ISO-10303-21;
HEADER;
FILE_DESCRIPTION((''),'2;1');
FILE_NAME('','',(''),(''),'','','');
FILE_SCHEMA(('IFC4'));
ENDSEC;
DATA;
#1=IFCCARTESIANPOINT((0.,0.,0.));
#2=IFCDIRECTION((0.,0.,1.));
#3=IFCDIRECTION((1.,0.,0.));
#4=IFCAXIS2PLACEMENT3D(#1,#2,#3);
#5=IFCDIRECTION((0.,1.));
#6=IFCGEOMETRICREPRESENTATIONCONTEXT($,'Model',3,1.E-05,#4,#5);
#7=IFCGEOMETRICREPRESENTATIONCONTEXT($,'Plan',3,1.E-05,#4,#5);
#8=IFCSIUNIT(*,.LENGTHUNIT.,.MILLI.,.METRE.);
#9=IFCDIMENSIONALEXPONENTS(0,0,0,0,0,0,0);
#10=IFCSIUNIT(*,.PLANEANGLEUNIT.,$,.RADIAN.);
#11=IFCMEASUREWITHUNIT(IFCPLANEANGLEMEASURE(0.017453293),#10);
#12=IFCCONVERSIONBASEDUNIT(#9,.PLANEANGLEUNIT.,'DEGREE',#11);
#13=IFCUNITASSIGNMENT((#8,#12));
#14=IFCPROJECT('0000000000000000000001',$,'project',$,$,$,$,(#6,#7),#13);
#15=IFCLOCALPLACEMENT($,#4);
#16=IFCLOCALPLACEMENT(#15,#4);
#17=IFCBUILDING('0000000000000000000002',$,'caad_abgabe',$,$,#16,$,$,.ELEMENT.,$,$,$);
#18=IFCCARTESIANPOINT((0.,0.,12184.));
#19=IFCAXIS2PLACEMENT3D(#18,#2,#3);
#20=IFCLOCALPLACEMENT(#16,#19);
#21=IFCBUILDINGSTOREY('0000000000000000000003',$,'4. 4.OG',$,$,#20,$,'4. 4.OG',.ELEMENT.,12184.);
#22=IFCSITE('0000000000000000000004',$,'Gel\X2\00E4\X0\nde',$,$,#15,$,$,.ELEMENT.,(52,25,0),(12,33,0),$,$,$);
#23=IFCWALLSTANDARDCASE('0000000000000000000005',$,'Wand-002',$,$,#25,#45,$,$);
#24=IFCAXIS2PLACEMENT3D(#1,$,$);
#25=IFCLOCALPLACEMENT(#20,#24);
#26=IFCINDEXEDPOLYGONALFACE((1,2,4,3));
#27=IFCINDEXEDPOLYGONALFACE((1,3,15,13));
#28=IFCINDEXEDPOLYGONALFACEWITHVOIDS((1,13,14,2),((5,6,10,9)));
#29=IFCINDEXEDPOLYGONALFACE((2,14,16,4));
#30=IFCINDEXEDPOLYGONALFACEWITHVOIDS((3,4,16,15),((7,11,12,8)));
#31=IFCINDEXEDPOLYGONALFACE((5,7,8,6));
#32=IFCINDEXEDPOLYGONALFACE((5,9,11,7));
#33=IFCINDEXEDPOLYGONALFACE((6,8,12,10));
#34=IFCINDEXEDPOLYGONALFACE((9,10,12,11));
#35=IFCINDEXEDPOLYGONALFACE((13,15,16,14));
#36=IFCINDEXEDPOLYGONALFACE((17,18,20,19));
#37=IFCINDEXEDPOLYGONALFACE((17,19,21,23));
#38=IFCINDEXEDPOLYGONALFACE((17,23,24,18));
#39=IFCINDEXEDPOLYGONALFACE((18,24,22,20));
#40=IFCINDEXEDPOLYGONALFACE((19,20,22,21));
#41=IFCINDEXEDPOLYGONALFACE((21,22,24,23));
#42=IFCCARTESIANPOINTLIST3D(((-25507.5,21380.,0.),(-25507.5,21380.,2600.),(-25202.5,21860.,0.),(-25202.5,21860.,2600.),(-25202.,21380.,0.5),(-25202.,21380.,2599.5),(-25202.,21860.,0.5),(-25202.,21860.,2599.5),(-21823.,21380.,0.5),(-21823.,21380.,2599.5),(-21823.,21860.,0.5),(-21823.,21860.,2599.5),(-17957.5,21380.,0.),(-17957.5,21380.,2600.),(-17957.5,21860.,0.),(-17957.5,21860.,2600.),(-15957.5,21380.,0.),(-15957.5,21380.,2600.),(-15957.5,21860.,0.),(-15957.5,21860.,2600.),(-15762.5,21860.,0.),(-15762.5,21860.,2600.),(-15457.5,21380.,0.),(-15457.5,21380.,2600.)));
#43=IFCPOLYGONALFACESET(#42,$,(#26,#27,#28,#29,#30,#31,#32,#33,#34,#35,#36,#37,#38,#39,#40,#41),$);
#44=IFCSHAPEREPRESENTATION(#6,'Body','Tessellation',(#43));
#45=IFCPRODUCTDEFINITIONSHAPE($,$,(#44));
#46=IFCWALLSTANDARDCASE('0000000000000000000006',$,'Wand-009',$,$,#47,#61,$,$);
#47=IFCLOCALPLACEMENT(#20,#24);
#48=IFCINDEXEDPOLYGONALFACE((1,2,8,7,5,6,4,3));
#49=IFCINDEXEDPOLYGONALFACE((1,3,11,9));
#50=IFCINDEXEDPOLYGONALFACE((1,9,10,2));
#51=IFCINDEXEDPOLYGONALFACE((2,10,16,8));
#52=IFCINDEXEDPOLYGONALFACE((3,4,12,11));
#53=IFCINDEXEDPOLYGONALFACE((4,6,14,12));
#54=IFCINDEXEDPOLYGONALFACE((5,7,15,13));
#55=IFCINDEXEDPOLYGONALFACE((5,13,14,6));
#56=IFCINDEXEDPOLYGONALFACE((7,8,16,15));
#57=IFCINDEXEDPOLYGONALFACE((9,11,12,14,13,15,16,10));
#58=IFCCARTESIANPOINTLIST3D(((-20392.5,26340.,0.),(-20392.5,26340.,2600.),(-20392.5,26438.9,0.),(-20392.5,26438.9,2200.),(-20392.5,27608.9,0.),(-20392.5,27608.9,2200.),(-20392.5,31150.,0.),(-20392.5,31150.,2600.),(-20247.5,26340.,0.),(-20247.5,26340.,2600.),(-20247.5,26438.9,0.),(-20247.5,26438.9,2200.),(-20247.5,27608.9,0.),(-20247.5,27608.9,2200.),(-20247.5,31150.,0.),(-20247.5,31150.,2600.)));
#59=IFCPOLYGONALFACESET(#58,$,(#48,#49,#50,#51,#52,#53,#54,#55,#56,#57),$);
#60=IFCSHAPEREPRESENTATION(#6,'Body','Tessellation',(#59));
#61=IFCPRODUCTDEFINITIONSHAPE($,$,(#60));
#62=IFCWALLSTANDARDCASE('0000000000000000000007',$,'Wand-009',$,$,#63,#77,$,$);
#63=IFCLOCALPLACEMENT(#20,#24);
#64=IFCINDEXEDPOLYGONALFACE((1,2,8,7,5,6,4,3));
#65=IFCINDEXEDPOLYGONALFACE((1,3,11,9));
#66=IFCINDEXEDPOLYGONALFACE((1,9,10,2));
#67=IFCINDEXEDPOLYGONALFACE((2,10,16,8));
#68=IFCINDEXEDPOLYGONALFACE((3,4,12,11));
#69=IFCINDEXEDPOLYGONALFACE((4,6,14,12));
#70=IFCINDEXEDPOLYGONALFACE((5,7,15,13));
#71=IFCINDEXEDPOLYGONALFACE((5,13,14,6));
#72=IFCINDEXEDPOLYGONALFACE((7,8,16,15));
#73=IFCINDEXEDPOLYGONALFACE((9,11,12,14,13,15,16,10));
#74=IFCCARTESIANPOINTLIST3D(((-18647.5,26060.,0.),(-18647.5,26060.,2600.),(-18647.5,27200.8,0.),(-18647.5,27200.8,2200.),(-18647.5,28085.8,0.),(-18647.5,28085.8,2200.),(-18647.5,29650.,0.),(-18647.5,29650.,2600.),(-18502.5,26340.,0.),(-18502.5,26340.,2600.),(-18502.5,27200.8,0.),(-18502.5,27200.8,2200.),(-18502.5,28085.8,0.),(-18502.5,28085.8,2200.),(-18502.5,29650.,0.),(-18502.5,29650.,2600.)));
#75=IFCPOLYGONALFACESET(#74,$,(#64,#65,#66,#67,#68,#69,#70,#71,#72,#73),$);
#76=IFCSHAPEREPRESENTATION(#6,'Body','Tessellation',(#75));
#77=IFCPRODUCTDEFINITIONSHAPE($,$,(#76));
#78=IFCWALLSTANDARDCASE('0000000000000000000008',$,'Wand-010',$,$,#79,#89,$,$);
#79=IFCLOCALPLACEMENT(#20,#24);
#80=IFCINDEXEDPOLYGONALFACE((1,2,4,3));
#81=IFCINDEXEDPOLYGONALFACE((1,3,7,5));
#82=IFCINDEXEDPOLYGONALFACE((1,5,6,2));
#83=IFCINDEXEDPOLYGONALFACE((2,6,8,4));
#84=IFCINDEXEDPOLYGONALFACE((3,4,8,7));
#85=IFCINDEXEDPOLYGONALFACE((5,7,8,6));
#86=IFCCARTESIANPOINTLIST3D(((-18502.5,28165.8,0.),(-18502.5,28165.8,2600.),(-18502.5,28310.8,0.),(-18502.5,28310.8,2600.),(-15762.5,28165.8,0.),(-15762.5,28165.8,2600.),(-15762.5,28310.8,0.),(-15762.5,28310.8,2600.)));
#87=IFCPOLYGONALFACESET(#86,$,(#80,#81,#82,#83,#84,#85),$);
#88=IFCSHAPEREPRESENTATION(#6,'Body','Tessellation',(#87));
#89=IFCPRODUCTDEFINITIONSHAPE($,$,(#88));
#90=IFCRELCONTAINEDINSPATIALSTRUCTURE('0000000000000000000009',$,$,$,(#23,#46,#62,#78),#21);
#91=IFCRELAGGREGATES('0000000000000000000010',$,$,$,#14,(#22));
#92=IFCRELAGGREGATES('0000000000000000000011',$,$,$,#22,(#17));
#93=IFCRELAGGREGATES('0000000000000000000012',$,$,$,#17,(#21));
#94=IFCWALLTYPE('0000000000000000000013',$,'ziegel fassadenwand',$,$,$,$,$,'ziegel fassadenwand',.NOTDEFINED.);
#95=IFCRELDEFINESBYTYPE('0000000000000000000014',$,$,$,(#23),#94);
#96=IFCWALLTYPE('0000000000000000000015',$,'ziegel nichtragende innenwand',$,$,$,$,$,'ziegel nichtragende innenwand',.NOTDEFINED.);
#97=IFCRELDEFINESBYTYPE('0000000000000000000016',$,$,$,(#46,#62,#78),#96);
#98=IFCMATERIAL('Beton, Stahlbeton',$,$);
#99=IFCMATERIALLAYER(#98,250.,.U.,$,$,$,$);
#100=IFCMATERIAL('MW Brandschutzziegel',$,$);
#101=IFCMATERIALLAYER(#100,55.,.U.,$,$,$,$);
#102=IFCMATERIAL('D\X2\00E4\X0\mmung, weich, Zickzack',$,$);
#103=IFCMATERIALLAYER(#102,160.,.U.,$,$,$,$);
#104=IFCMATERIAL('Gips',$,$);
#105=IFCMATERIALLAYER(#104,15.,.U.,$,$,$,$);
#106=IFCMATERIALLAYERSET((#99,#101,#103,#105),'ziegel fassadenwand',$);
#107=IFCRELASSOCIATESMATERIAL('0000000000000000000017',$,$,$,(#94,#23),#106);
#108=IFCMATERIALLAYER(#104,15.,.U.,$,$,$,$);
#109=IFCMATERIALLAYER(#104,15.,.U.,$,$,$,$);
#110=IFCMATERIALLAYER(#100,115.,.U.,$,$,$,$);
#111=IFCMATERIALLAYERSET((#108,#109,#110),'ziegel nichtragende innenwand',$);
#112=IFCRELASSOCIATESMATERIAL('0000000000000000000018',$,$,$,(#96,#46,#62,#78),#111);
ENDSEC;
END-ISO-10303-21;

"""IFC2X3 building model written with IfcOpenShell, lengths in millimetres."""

from ifc_helpers import new_model, entity, si_unit, converted_unit, direction, frame, frame_2d, origin_with_axes, place, context, project, spatial, polyline, rectangle, outline, extrude, material, layer, layer_set, layer_usage, type_object, element, save


model = new_model("IFC2X3")

# Units and contexts
model_context = context("Model", 3, precision=1e-05, world=origin_with_axes(), true_north=direction((0.0, 1.0)))
plan_context = context("Plan", 3, precision=1e-05, world=origin_with_axes(), true_north=direction((0.0, 1.0)))
ifc_project = project(units=[si_unit("LENGTHUNIT", "METRE", prefix="MILLI"), converted_unit("PLANEANGLEUNIT", "DEGREE", entity("IfcPlaneAngleMeasure", 0.017453293), si_unit("PLANEANGLEUNIT", "RADIAN"), dimensions=[0, 0, 0, 0, 0, 0, 0])], contexts=[model_context, plan_context])

# Site, building, storey
site_placement = place(None, origin_with_axes())
site = spatial("IfcSite", under=ifc_project, at=site_placement, Name="Gelände", CompositionType="ELEMENT", RefLatitude=(52, 25, 0), RefLongitude=(12, 33, 0))
building_placement = place(site_placement, origin_with_axes())
building = spatial("IfcBuilding", under=site, at=building_placement, Name="caad_abgabe", CompositionType="ELEMENT")
storey_placement = place(building_placement, frame((0.0, 0.0, 12184.0), z_axis=(0.0, 0.0, 1.0), x_axis=(1.0, 0.0, 0.0)))
storey = spatial("IfcBuildingStorey", under=building, at=storey_placement, Name="4. 4.OG", LongName="4. 4.OG", CompositionType="ELEMENT", Elevation=12184.0)

# Shared definitions
ifc_material_1 = material(Name="Gips")
ifc_material_2 = material(Name="Beton, Stahlbeton")

# Wall, openings
ifc_layer_1 = layer(ifc_material_2, 250.0, ventilated="UNKNOWN")
ifc_material_3 = material(Name="MW Brandschutzziegel")
ifc_layer_2 = layer(ifc_material_3, 55.0, ventilated="UNKNOWN")
ifc_material_4 = material(Name="Dämmung, weich, Zickzack")
ifc_layer_3 = layer(ifc_material_4, 160.0, ventilated="UNKNOWN")
ifc_layer_4 = layer(ifc_material_1, 15.0, ventilated="UNKNOWN")
ifc_layer_set_1 = layer_set([ifc_layer_1, ifc_layer_2, ifc_layer_3, ifc_layer_4], Name="ziegel fassadenwand")
ifc_layer_usage_1 = layer_usage(ifc_layer_set_1, "AXIS2", "POSITIVE", 0.0)
wall_type_1 = type_object("IfcWallType", Name="ziegel fassadenwand", ElementType="ziegel fassadenwand", PredefinedType="NOTDEFINED", material=ifc_layer_set_1)
wall_1_placement = place(storey_placement, frame((-25507.5, 21380.0, 0.0), z_axis=(0.0, 0.0, 1.0), x_axis=(1.0, 0.0, 0.0)))
wall_1 = element("IfcWallStandardCase", 1, at=wall_1_placement, inside=storey, type_object=wall_type_1, material=ifc_layer_usage_1, Name="Wand-002", context=model_context, shape_type="SweptSolid", body=[
    extrude(outline(polyline([(0.0, 0.0), (10050.0, 0.0), (9745.0, 480.0), (305.0, 480.0), (0.0, 0.0)])), origin_with_axes(), (0.0, 0.0, 1.0), 2600.0),
])
opening_1_placement = place(wall_1_placement, frame((1995.0, 0.0, 0.0), z_axis=(0.0, 0.0, 1.0), x_axis=(1.0, 0.0, 0.0)))
element("IfcOpeningElement", 2, at=opening_1_placement, cuts=wall_1, ObjectType="Opening", context=model_context, shape_type="SweptSolid", body=[
    extrude(rectangle(XDim=3379.0, YDim=2599.0, at=frame_2d((0.0, 1300.0), x_axis=(1.0, 0.0))), frame((0.0, 0.0, 0.0), z_axis=(0.0, 1.0, 0.0), x_axis=(-1.0, 0.0, 0.0)), (0.0, 0.0, 1.0), 480.0),
])
opening_2_placement = place(wall_1_placement, frame((8550.0, 0.0, 0.0), z_axis=(0.0, 0.0, 1.0), x_axis=(1.0, 0.0, 0.0)))
element("IfcOpeningElement", 3, at=opening_2_placement, cuts=wall_1, ObjectType="Opening", context=model_context, shape_type="SweptSolid", body=[
    extrude(rectangle(XDim=2000.0, YDim=2600.0, at=frame_2d((0.0, 1300.0), x_axis=(1.0, 0.0))), frame((0.0, 0.0, 0.0), z_axis=(0.0, 1.0, 0.0), x_axis=(-1.0, 0.0, 0.0)), (0.0, 0.0, 1.0), 480.0),
])

# Walls, openings
ifc_layer_5 = layer(ifc_material_1, 15.0, ventilated="UNKNOWN")
ifc_layer_6 = layer(ifc_material_1, 15.0, ventilated="UNKNOWN")
ifc_layer_7 = layer(ifc_material_3, 115.0, ventilated="UNKNOWN")
ifc_layer_set_2 = layer_set([ifc_layer_5, ifc_layer_6, ifc_layer_7], Name="ziegel nichtragende innenwand")
ifc_layer_usage_2 = layer_usage(ifc_layer_set_2, "AXIS2", "POSITIVE", 0.0)
wall_type_2 = type_object("IfcWallType", Name="ziegel nichtragende innenwand", ElementType="ziegel nichtragende innenwand", PredefinedType="NOTDEFINED", material=ifc_layer_set_2)
wall_2_placement = place(storey_placement, frame((-20392.5, 31150.0, 0.0), z_axis=(0.0, 0.0, 1.0), x_axis=(0.0, -1.0, 0.0)))
wall_2 = element("IfcWallStandardCase", 4, at=wall_2_placement, inside=storey, type_object=wall_type_2, material=ifc_layer_usage_2, Name="Wand-009", context=model_context, shape_type="SweptSolid", body=[
    extrude(outline(polyline([(0.0, 0.0), (4810.0, 0.0), (4810.0, 145.0), (0.0, 145.0), (0.0, 0.0)])), origin_with_axes(), (0.0, 0.0, 1.0), 2600.0),
])
opening_3_placement = place(wall_2_placement, frame((4126.2, 0.0, 0.0), z_axis=(0.0, 0.0, 1.0), x_axis=(1.0, 0.0, 0.0)))
element("IfcOpeningElement", 5, at=opening_3_placement, cuts=wall_2, ObjectType="Opening", context=model_context, shape_type="SweptSolid", body=[
    extrude(rectangle(XDim=1170.0, YDim=2200.0, at=frame_2d((0.0, 1100.0), x_axis=(-1.0, 0.0))), frame((0.0, 0.0, 0.0), z_axis=(0.0, 1.0, 0.0), x_axis=(-1.0, 0.0, 0.0)), (0.0, 0.0, 1.0), 145.0),
])
ifc_layer_usage_3 = layer_usage(ifc_layer_set_2, "AXIS2", "NEGATIVE", 0.0)
wall_3_placement = place(storey_placement, frame((-18647.5, 26340.0, 0.0), z_axis=(0.0, 0.0, 1.0), x_axis=(0.0, 1.0, 0.0)))
wall_3 = element("IfcWallStandardCase", 6, at=wall_3_placement, inside=storey, type_object=wall_type_2, material=ifc_layer_usage_3, Name="Wand-009", context=model_context, shape_type="SweptSolid", body=[
    extrude(outline(polyline([(0.0, -145.0), (3310.0, -145.0), (3310.0, 0.0), (-280.0, 0.0), (0.0, -145.0)])), origin_with_axes(), (0.0, 0.0, 1.0), 2600.0),
])
opening_4_placement = place(wall_3_placement, frame((1303.2, -145.0, 0.0), z_axis=(0.0, 0.0, 1.0), x_axis=(1.0, 0.0, 0.0)))
element("IfcOpeningElement", 7, at=opening_4_placement, cuts=wall_3, ObjectType="Opening", context=model_context, shape_type="SweptSolid", body=[
    extrude(rectangle(XDim=885.0, YDim=2200.0, at=frame_2d((0.0, 1100.0), x_axis=(-1.0, 0.0))), frame((0.0, 0.0, 0.0), z_axis=(0.0, 1.0, 0.0), x_axis=(-1.0, 0.0, 0.0)), (0.0, 0.0, 1.0), 145.0),
])

# Wall
ifc_layer_usage_4 = layer_usage(ifc_layer_set_2, "AXIS2", "NEGATIVE", 72.5)
wall_4_placement = place(storey_placement, frame((-18647.5, 28238.3, 0.0), z_axis=(0.0, 0.0, 1.0), x_axis=(1.0, 0.0, 0.0)))
element("IfcWallStandardCase", 8, at=wall_4_placement, inside=storey, type_object=wall_type_2, material=ifc_layer_usage_4, Name="Wand-010", context=model_context, shape_type="SweptSolid", body=[
    extrude(outline(polyline([(145.0, -72.5), (2885.0, -72.5), (2885.0, 72.5), (145.0, 72.5), (145.0, -72.5)])), origin_with_axes(), (0.0, 0.0, 1.0), 2600.0),
])

save(model, "model.ifc")
